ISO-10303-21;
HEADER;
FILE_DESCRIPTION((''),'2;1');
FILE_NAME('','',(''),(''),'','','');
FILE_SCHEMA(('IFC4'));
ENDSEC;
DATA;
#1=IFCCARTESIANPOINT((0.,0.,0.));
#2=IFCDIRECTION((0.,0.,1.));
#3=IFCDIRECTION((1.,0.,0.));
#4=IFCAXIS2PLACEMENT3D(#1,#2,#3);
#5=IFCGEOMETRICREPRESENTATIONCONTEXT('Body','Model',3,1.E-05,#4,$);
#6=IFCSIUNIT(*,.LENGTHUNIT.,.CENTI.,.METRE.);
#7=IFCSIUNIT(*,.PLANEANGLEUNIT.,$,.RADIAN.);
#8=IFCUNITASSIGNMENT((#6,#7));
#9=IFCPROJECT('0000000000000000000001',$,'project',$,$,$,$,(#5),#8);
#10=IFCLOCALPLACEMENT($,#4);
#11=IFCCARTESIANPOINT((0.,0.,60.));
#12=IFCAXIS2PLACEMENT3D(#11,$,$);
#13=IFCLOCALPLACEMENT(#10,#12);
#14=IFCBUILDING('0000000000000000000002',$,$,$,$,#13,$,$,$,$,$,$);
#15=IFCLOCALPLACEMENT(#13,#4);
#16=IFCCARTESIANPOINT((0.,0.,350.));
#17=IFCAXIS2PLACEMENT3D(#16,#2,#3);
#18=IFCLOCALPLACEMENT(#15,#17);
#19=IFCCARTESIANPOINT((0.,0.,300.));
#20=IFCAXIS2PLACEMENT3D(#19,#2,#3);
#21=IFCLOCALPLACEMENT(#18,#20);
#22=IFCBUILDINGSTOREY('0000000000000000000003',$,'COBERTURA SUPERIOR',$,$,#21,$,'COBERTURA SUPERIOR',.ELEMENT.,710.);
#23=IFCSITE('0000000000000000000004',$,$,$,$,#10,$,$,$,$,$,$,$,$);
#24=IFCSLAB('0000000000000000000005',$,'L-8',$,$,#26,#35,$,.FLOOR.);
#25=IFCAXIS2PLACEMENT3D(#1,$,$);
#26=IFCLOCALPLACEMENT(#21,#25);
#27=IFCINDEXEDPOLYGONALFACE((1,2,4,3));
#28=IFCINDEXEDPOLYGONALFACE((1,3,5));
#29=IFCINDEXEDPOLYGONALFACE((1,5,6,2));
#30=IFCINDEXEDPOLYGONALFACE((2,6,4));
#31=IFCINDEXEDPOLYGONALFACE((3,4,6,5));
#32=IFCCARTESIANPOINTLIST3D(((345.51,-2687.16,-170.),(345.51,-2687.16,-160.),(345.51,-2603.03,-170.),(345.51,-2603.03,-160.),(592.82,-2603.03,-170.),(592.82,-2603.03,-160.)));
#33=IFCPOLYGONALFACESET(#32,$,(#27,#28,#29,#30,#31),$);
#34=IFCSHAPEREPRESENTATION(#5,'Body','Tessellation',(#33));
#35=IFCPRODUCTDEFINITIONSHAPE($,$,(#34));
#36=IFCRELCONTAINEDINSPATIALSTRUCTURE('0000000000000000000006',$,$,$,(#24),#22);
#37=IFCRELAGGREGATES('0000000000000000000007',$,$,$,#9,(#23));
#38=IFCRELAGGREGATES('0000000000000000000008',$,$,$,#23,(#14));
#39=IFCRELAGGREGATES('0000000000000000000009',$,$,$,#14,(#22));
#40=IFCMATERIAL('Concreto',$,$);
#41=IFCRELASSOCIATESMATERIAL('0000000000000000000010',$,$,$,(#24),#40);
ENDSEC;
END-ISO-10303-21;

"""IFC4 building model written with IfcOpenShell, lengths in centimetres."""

from ifc_helpers import new_model, si_unit, frame, origin_with_axes, place, context, project, spatial, polyline, outline, extrude, material, element, save


model = new_model("IFC4")

# Units and contexts
model_context = context("Model", 3, precision=1e-05, world=origin_with_axes(), identifier="Body")
ifc_project = project(units=[si_unit("LENGTHUNIT", "METRE", prefix="CENTI"), si_unit("PLANEANGLEUNIT", "RADIAN")], contexts=[model_context])

# Site, building, storey
site_placement = place(None, origin_with_axes())
site = spatial("IfcSite", under=ifc_project, at=site_placement)
building_placement = place(site_placement, frame((0.0, 0.0, 60.0)))
building = spatial("IfcBuilding", under=site, at=building_placement)
placement_1 = place(building_placement, origin_with_axes())
placement_2 = place(placement_1, frame((0.0, 0.0, 350.0), z_axis=(0.0, 0.0, 1.0), x_axis=(1.0, 0.0, 0.0)))
storey_placement = place(placement_2, frame((0.0, 0.0, 300.0), z_axis=(0.0, 0.0, 1.0), x_axis=(1.0, 0.0, 0.0)))
storey = spatial("IfcBuildingStorey", under=building, at=storey_placement, Name="COBERTURA SUPERIOR", LongName="COBERTURA SUPERIOR", CompositionType="ELEMENT", Elevation=710.0)

# Shared definitions
ifc_material = material(Name="Concreto")

# Slab
slab_1_placement = place(storey_placement, frame((469.17, -2645.1, -160.0), z_axis=(0.0, 0.0, 1.0), x_axis=(1.0, 0.0, 0.0)))
element("IfcSlab", 1, at=slab_1_placement, inside=storey, material=ifc_material, Name="L-8", PredefinedType="FLOOR", context=model_context, shape_type="SolidModel", body=[
    extrude(outline(polyline([(123.66, 42.07), (-123.66, 42.07), (-123.66, -42.07), (123.66, 42.07), (123.66, 42.07)])), frame((0.0, 0.0, -10.0), z_axis=(0.0, 0.0, 1.0), x_axis=(1.0, 0.0, 0.0)), (0.0, 0.0, 1.0), 10.0),
])

save(model, "model.ifc")
